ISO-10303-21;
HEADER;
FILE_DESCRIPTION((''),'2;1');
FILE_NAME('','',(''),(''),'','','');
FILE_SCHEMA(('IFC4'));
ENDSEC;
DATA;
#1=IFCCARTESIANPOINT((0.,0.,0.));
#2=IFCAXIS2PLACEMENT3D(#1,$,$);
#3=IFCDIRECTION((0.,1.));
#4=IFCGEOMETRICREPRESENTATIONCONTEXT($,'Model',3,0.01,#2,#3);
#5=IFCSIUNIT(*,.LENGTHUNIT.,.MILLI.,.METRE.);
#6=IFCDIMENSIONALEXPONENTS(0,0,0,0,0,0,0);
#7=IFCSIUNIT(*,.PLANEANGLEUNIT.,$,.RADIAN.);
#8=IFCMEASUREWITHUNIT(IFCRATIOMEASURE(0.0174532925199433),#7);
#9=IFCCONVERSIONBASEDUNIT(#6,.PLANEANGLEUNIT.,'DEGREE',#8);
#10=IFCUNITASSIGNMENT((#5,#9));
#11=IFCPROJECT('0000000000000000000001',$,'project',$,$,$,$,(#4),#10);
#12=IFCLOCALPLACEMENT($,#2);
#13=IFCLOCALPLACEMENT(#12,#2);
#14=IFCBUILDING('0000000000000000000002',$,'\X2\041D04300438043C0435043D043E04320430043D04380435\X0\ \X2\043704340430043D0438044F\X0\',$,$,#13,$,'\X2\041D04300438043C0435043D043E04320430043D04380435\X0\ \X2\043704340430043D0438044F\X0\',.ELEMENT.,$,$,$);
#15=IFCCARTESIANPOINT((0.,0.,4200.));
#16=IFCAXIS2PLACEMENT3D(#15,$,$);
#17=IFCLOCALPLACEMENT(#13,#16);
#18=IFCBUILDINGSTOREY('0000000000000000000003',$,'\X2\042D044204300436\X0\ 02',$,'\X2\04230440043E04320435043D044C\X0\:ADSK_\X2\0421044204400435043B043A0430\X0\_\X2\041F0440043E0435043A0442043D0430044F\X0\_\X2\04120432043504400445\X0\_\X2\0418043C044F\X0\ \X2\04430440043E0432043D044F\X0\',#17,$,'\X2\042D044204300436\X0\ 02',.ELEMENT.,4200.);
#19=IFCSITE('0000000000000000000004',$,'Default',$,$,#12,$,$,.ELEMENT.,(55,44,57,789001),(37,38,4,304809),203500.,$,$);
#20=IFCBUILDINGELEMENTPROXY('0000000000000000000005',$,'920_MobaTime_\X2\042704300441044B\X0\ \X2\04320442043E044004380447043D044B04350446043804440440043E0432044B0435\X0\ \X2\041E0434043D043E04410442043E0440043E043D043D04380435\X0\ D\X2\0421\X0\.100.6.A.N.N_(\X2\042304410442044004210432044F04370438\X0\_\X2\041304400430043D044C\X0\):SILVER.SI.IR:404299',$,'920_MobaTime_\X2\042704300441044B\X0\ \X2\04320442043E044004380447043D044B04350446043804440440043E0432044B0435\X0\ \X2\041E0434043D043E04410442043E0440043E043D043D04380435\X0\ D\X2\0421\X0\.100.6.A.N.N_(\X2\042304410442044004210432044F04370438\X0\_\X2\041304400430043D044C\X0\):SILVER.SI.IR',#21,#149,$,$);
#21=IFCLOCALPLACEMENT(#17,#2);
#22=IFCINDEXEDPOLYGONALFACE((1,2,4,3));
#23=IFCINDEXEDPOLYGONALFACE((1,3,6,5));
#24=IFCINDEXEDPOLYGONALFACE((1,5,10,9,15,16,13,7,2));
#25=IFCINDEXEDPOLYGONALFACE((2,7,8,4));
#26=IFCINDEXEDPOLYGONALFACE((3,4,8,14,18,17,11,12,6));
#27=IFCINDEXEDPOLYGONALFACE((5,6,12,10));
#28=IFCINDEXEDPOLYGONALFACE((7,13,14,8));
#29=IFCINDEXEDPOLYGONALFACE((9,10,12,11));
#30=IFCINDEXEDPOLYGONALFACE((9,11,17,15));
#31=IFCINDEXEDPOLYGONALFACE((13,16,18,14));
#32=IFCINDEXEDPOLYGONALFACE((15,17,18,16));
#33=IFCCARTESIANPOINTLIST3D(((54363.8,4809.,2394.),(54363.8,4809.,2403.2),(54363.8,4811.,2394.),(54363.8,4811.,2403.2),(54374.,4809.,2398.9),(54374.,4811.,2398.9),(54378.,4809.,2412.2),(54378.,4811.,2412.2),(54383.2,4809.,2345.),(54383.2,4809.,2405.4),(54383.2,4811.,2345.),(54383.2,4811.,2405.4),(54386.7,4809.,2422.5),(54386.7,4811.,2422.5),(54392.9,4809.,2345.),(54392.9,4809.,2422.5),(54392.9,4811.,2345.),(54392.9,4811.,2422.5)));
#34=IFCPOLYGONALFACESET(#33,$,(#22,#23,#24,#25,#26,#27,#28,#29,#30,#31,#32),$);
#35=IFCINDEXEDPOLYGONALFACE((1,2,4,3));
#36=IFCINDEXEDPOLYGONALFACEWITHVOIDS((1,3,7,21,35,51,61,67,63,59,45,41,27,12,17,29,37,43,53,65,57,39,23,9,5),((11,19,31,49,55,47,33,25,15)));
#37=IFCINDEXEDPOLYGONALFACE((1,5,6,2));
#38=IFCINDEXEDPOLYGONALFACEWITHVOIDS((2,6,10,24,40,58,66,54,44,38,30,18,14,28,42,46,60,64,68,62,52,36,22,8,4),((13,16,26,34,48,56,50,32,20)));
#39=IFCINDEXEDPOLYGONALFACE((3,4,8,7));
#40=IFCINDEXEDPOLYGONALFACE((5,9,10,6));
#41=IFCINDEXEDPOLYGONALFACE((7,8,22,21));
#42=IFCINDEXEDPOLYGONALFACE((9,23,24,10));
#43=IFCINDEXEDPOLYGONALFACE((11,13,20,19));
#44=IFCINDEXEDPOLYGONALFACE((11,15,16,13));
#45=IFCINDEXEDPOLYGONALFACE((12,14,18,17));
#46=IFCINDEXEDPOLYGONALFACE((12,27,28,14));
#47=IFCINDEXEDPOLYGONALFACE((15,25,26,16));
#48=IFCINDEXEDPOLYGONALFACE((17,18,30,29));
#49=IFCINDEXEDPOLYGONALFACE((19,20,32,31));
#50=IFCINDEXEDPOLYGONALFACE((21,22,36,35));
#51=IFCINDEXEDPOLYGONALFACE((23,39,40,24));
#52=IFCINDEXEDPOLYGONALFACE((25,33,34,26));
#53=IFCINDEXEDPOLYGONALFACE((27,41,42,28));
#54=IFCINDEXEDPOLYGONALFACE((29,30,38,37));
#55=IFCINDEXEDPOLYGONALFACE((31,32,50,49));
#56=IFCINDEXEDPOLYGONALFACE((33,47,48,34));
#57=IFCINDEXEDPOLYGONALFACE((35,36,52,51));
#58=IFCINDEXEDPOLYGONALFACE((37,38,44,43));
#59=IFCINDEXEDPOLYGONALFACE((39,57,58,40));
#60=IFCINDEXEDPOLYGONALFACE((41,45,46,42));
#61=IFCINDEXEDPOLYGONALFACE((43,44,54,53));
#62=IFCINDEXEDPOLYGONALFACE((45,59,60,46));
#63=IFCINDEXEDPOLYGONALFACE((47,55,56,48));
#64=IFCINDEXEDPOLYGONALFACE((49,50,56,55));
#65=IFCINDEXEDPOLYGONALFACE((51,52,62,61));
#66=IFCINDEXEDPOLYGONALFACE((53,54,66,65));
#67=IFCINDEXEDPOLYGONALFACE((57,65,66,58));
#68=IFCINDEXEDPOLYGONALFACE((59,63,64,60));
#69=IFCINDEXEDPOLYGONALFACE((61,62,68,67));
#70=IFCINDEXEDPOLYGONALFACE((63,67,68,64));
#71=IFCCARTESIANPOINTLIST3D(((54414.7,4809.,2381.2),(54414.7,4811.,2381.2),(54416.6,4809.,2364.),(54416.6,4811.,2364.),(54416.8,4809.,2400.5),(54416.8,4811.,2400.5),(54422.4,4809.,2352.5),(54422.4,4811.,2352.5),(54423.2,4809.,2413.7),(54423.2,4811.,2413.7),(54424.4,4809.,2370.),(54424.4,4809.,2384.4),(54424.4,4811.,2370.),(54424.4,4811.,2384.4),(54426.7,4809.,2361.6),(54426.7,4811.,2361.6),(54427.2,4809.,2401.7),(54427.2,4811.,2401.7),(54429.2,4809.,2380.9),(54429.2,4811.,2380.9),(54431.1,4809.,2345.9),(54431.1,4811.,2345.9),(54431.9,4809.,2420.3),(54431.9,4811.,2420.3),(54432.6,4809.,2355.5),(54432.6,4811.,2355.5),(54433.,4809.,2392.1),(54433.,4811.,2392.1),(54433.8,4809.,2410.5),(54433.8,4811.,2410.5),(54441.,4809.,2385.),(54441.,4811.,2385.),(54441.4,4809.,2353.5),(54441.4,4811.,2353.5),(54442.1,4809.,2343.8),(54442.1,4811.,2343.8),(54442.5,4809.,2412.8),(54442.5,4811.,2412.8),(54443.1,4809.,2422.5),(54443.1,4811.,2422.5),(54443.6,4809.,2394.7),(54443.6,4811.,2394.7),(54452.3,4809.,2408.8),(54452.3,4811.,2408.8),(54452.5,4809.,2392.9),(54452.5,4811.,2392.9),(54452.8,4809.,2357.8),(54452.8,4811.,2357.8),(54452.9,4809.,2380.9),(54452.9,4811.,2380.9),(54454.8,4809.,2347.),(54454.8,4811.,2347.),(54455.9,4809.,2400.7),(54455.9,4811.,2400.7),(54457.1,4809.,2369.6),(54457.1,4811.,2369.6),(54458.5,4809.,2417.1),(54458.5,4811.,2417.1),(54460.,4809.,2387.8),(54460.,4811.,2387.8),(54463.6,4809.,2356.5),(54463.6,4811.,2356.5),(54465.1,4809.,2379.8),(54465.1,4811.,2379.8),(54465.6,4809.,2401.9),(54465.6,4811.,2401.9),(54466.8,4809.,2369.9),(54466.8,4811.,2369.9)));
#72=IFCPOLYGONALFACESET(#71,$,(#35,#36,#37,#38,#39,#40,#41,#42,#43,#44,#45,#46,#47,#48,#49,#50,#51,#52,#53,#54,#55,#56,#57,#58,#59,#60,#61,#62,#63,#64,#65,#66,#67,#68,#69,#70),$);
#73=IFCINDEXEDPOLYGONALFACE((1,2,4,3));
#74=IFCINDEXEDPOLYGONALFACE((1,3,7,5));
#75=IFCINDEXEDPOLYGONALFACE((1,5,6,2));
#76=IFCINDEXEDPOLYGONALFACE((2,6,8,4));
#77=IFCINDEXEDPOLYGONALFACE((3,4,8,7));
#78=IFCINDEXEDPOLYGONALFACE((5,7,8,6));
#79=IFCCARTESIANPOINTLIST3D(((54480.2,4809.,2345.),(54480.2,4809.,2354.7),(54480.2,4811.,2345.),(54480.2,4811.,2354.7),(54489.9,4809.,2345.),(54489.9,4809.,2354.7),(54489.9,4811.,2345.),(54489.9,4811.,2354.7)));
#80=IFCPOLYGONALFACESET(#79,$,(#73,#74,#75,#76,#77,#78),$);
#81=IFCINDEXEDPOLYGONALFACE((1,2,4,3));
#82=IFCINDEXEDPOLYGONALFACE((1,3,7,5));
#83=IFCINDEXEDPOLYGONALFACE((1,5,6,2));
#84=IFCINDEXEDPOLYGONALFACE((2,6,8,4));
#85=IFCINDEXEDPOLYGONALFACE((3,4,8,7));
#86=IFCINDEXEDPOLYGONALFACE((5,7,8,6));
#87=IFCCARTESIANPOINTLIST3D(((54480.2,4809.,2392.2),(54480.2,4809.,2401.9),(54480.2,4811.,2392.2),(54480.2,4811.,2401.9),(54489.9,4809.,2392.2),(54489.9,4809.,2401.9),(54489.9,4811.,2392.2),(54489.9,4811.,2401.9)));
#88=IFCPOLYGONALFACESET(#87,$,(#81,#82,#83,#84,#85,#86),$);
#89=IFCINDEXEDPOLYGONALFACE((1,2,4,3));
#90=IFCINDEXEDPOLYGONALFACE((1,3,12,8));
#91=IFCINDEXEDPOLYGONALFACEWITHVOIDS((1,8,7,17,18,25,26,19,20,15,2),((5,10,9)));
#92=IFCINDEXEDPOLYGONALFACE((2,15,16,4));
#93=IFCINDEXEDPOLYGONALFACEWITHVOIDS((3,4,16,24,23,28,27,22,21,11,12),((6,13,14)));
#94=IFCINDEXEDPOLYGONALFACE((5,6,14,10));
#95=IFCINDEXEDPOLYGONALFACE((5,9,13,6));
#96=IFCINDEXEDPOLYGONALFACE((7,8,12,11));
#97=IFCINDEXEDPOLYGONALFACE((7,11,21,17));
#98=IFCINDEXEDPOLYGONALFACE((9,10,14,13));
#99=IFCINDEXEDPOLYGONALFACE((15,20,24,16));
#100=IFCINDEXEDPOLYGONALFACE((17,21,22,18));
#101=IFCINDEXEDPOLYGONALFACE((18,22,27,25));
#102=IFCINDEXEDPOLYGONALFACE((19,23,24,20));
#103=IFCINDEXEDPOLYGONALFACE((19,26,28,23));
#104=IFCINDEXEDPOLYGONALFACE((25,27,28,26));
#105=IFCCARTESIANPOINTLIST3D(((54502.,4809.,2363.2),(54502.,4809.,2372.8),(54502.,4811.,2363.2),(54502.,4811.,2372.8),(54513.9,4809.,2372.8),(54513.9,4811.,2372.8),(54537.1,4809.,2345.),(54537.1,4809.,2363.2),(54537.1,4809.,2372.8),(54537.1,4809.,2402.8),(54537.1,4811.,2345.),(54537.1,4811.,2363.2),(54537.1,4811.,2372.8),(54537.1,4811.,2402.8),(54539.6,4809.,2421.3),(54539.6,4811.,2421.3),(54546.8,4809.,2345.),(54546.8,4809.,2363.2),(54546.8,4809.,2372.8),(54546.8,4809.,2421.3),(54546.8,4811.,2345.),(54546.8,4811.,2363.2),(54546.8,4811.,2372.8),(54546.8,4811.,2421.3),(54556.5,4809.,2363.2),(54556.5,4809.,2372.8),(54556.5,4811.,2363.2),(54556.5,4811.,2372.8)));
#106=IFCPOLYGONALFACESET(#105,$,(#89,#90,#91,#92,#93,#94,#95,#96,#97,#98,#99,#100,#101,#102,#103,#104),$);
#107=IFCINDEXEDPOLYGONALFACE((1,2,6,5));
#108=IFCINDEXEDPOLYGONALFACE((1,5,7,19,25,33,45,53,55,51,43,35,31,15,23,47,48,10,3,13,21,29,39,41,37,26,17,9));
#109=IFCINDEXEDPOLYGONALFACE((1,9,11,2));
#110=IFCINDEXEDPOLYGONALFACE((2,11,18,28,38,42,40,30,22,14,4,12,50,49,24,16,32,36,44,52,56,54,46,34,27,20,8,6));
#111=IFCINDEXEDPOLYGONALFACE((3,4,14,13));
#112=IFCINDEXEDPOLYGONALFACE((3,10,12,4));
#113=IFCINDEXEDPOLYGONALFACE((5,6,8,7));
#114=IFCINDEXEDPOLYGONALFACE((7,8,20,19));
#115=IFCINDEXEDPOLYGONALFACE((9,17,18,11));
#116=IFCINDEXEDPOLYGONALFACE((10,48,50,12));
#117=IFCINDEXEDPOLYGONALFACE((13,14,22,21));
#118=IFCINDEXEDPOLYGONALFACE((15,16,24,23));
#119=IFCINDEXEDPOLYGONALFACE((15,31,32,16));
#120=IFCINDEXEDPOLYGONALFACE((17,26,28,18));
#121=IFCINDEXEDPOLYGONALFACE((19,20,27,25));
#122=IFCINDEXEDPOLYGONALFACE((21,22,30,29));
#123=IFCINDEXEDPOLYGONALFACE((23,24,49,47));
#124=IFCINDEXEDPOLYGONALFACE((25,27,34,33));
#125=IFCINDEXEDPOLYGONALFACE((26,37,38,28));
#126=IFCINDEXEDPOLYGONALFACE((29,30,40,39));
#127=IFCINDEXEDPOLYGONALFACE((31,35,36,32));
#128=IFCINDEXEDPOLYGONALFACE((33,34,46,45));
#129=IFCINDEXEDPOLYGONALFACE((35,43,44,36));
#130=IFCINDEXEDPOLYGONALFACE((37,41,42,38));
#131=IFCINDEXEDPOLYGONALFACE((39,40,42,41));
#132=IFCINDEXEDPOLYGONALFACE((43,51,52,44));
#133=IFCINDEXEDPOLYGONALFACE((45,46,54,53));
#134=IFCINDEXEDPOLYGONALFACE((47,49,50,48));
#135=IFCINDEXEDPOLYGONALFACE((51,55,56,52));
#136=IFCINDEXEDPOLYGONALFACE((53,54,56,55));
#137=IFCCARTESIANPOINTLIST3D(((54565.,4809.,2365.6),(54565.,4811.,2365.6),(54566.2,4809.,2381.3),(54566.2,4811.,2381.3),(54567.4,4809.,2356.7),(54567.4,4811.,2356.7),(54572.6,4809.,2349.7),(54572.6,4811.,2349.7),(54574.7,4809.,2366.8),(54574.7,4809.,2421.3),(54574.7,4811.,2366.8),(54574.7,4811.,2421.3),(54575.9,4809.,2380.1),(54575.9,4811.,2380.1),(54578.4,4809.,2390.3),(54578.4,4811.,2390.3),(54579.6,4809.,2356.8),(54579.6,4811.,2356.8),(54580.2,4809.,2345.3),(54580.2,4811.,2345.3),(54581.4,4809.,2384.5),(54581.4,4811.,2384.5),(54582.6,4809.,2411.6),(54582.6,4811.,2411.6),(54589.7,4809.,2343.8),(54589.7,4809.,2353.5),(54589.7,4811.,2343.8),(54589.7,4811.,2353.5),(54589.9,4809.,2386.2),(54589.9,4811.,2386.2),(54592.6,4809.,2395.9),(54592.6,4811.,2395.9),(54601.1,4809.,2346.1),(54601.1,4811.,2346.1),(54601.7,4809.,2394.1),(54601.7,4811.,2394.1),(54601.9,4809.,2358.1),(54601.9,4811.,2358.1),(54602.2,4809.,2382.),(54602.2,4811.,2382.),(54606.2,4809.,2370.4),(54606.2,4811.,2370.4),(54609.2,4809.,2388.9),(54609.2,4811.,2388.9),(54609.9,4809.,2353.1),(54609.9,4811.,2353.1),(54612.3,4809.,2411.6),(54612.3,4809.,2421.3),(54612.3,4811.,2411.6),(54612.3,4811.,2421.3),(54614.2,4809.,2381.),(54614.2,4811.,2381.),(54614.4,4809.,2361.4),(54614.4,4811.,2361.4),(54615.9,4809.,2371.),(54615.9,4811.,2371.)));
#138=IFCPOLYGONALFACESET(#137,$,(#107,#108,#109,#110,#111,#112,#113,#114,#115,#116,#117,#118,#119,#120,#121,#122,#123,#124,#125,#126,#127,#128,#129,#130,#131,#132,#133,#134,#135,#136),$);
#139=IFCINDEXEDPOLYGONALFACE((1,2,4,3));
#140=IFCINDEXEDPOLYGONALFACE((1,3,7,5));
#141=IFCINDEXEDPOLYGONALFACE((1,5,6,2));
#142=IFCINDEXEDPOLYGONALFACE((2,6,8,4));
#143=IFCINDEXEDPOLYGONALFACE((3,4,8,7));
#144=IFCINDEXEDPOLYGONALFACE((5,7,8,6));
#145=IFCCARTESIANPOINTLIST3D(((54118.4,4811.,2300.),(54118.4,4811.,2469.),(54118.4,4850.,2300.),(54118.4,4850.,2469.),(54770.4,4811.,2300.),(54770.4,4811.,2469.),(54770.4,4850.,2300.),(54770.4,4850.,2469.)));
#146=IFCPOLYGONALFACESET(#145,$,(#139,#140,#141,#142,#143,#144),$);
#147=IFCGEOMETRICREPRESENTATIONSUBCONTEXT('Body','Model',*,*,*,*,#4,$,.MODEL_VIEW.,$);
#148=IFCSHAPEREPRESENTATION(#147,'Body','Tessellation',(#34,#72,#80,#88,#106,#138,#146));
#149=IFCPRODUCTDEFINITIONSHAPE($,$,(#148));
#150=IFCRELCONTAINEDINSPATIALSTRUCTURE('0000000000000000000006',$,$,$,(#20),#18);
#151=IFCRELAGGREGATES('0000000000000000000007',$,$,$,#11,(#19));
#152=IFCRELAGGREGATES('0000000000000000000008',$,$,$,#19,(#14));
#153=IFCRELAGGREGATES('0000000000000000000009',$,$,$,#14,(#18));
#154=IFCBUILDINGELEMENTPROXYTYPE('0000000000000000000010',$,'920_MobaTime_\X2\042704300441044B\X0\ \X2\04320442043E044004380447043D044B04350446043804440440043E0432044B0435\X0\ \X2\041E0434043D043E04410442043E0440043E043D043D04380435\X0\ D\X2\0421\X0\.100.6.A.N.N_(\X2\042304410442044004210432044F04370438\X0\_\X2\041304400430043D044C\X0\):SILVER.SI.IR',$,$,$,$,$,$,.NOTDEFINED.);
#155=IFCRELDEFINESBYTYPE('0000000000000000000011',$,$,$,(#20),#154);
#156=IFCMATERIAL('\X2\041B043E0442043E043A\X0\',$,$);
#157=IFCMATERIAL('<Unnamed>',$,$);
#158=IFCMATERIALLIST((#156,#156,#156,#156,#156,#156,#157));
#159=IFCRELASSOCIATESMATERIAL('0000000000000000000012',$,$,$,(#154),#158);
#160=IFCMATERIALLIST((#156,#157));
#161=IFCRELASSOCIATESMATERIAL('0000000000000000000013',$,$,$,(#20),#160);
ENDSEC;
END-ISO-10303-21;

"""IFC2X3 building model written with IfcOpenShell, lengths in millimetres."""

from ifc_helpers import new_model, entity, si_unit, converted_unit, direction, frame, origin, origin_2d_with_axis, place, context, subcontext, project, spatial, polyline, rectangle, outline, extrude, source, transform, mapped, material, material_list, type_object, type_shapes, element, save


model = new_model("IFC2X3")

# Units and contexts
model_context = context("Model", 3, precision=0.01, world=origin(), true_north=direction((0.0, 1.0)))
body_context = subcontext(model_context, "Body", "Model", "MODEL_VIEW")
ifc_project = project(units=[si_unit("LENGTHUNIT", "METRE", prefix="MILLI"), converted_unit("PLANEANGLEUNIT", "DEGREE", entity("IfcRatioMeasure", 0.0174532925199433), si_unit("PLANEANGLEUNIT", "RADIAN"), dimensions=[0, 0, 0, 0, 0, 0, 0])], contexts=[model_context])

# Site, building, storey
site_placement = place(None, frame((0.0, 0.0, 0.0)))
site = spatial("IfcSite", under=ifc_project, at=site_placement, Name="Default", CompositionType="ELEMENT", RefLatitude=(55, 44, 57, 789001), RefLongitude=(37, 38, 4, 304809), RefElevation=203500.0)
building_placement = place(site_placement, origin())
building = spatial("IfcBuilding", under=site, at=building_placement, Name="Наименование здания", LongName="Наименование здания", CompositionType="ELEMENT")
storey_placement = place(building_placement, frame((0.0, 0.0, 4200.0)))
storey = spatial("IfcBuildingStorey", under=building, at=storey_placement, Name="Этаж 02", ObjectType="Уровень:ADSK_Стрелка_Проектная_Вверх_Имя уровня", LongName="Этаж 02", CompositionType="ELEMENT", Elevation=4200.0)

# Building element proxy
ifc_material_1 = material(Name="Лоток")
ifc_material_2 = material(Name="<Unnamed>")
ifc_material_list_1 = material_list([ifc_material_1, ifc_material_1, ifc_material_1, ifc_material_1, ifc_material_1, ifc_material_1, ifc_material_2])
building_element_proxy_type_1 = type_object("IfcBuildingElementProxyType", Name="920_MobaTime_Часы вторичныецифровые Односторонние DС.100.6.A.N.N_(УстрСвязи_Грань):SILVER.SI.IR", PredefinedType="NOTDEFINED", material=ifc_material_list_1)
shared_shape_1 = source(origin(), body_context, "Body", "SweptSolid", [
    extrude(outline(polyline([(-49.3, -13.1), (28.2, -13.1), (28.2, -6.8), (17.9, 1.8), (8.9, 16.0), (-0.3, 16.0), (4.6, 5.8), (11.1, -3.4), (-49.3, -3.4), (-49.3, -13.1)])), frame((-64.6, 9.8, 39.0), z_axis=(0.0, 0.0, 1.0), x_axis=(0.0, 1.0, 0.0)), (0.0, 0.0, 1.0), 2.0),
    extrude(outline(polyline([(2.2, -27.6), (19.0, -27.6), (30.5, -16.1), (33.3, -4.9), (31.0, 5.8), (21.8, 17.2), (5.2, 27.3), (-11.1, 33.0), (-24.0, 32.7), (-33.6, 27.6), (-40.3, 18.6), (-42.8, 5.7), (-38.0, -6.3), (-27.2, -15.0), (-17.5, -17.7), (-8.2, -16.4), (-0.3, -11.9), (5.1, -4.5), (7.3, 6.2), (4.0, 17.2), (18.5, 7.3), (23.6, -2.4), (22.0, -11.4), (14.2, -18.4), (5.3, -18.3), (2.2, -27.6)]), holes=[polyline([(-9.0, 23.3), (-1.3, 14.4), (-2.6, 2.0), (-11.4, -7.0), (-23.4, -6.1), (-32.2, 2.9), (-31.2, 15.1), (-25.6, 22.1), (-17.5, 24.9), (-9.0, 23.3)])]), frame((-2.7, 3.6, 39.0), z_axis=(0.0, 0.0, 1.0), x_axis=(-0.427649, 0.903945, 0.0)), (0.0, 0.0, 1.0), 2.0),
    extrude(rectangle(XDim=9.7, YDim=9.7, at=origin_2d_with_axis()), frame((40.6, -34.7, 39.0)), (0.0, 0.0, 1.0), 2.0),
    extrude(rectangle(XDim=9.7, YDim=9.7, at=origin_2d_with_axis()), frame((40.6, 12.6, 39.0)), (0.0, 0.0, 1.0), 2.0),
    extrude(outline(polyline([(-0.9, -28.1), (8.8, -28.1), (8.8, -9.9), (18.5, -9.9), (18.5, -0.2), (8.8, -0.2), (8.8, 48.3), (1.5, 48.3), (-36.0, -0.2), (-36.0, -9.9), (-0.9, -9.9), (-0.9, -28.1)]), holes=[polyline([(-0.9, -0.2), (-24.1, -0.2), (-0.9, 29.7), (-0.9, -0.2)])]), frame((93.6, -11.4, 39.0)), (0.0, 0.0, 1.0), 2.0),
    extrude(outline(polyline([(3.3, -28.3), (12.5, -28.3), (20.5, -25.0), (26.8, -18.8), (30.7, -10.0), (31.4, 1.6), (26.9, 11.8), (20.1, 18.4), (11.1, 22.3), (1.0, 23.3), (-7.9, 20.4), (-14.9, 14.5), (-18.9, 6.2), (-17.1, -9.0), (-36.7, 0.5), (-29.1, 29.3), (-38.5, 31.7), (-48.1, -4.6), (-11.6, -23.0), (-8.0, -14.0), (-10.8, -7.6), (-10.2, 1.1), (-3.0, 11.8), (9.2, 12.8), (20.0, 5.4), (21.3, -7.5), (15.5, -16.4), (4.6, -18.6), (3.3, -28.3)])), frame((147.1, -8.5, 39.0), z_axis=(0.0, 0.0, 1.0), x_axis=(0.256974, -0.966418, 0.0)), (0.0, 0.0, 1.0), 2.0),
    extrude(rectangle(XDim=652.0, YDim=169.0, at=origin_2d_with_axis()), frame((0.0, 0.0, 0.0), z_axis=(0.0, 0.0, 1.0), x_axis=(-1.0, 0.0, 0.0)), (0.0, 0.0, 1.0), 39.0),
])
type_shapes(building_element_proxy_type_1, [shared_shape_1])
ifc_material_list_2 = material_list([ifc_material_1, ifc_material_2])
proxy_1_placement = place(storey_placement, frame((54444.4, 4850.0, 2384.5), z_axis=(0.0, -1.0, 0.0), x_axis=(1.0, 0.0, 0.0)))
element("IfcBuildingElementProxy", 1, at=proxy_1_placement, inside=storey, type_object=building_element_proxy_type_1, material=ifc_material_list_2, Name="920_MobaTime_Часы вторичныецифровые Односторонние DС.100.6.A.N.N_(УстрСвязи_Грань):SILVER.SI.IR:404299", ObjectType="920_MobaTime_Часы вторичныецифровые Односторонние DС.100.6.A.N.N_(УстрСвязи_Грань):SILVER.SI.IR", context=body_context, shape_type="MappedRepresentation", body=[
    mapped(shared_shape_1, transform((0.0, 0.0, 0.0), scale=1.0)),
])

save(model, "model.ifc")
